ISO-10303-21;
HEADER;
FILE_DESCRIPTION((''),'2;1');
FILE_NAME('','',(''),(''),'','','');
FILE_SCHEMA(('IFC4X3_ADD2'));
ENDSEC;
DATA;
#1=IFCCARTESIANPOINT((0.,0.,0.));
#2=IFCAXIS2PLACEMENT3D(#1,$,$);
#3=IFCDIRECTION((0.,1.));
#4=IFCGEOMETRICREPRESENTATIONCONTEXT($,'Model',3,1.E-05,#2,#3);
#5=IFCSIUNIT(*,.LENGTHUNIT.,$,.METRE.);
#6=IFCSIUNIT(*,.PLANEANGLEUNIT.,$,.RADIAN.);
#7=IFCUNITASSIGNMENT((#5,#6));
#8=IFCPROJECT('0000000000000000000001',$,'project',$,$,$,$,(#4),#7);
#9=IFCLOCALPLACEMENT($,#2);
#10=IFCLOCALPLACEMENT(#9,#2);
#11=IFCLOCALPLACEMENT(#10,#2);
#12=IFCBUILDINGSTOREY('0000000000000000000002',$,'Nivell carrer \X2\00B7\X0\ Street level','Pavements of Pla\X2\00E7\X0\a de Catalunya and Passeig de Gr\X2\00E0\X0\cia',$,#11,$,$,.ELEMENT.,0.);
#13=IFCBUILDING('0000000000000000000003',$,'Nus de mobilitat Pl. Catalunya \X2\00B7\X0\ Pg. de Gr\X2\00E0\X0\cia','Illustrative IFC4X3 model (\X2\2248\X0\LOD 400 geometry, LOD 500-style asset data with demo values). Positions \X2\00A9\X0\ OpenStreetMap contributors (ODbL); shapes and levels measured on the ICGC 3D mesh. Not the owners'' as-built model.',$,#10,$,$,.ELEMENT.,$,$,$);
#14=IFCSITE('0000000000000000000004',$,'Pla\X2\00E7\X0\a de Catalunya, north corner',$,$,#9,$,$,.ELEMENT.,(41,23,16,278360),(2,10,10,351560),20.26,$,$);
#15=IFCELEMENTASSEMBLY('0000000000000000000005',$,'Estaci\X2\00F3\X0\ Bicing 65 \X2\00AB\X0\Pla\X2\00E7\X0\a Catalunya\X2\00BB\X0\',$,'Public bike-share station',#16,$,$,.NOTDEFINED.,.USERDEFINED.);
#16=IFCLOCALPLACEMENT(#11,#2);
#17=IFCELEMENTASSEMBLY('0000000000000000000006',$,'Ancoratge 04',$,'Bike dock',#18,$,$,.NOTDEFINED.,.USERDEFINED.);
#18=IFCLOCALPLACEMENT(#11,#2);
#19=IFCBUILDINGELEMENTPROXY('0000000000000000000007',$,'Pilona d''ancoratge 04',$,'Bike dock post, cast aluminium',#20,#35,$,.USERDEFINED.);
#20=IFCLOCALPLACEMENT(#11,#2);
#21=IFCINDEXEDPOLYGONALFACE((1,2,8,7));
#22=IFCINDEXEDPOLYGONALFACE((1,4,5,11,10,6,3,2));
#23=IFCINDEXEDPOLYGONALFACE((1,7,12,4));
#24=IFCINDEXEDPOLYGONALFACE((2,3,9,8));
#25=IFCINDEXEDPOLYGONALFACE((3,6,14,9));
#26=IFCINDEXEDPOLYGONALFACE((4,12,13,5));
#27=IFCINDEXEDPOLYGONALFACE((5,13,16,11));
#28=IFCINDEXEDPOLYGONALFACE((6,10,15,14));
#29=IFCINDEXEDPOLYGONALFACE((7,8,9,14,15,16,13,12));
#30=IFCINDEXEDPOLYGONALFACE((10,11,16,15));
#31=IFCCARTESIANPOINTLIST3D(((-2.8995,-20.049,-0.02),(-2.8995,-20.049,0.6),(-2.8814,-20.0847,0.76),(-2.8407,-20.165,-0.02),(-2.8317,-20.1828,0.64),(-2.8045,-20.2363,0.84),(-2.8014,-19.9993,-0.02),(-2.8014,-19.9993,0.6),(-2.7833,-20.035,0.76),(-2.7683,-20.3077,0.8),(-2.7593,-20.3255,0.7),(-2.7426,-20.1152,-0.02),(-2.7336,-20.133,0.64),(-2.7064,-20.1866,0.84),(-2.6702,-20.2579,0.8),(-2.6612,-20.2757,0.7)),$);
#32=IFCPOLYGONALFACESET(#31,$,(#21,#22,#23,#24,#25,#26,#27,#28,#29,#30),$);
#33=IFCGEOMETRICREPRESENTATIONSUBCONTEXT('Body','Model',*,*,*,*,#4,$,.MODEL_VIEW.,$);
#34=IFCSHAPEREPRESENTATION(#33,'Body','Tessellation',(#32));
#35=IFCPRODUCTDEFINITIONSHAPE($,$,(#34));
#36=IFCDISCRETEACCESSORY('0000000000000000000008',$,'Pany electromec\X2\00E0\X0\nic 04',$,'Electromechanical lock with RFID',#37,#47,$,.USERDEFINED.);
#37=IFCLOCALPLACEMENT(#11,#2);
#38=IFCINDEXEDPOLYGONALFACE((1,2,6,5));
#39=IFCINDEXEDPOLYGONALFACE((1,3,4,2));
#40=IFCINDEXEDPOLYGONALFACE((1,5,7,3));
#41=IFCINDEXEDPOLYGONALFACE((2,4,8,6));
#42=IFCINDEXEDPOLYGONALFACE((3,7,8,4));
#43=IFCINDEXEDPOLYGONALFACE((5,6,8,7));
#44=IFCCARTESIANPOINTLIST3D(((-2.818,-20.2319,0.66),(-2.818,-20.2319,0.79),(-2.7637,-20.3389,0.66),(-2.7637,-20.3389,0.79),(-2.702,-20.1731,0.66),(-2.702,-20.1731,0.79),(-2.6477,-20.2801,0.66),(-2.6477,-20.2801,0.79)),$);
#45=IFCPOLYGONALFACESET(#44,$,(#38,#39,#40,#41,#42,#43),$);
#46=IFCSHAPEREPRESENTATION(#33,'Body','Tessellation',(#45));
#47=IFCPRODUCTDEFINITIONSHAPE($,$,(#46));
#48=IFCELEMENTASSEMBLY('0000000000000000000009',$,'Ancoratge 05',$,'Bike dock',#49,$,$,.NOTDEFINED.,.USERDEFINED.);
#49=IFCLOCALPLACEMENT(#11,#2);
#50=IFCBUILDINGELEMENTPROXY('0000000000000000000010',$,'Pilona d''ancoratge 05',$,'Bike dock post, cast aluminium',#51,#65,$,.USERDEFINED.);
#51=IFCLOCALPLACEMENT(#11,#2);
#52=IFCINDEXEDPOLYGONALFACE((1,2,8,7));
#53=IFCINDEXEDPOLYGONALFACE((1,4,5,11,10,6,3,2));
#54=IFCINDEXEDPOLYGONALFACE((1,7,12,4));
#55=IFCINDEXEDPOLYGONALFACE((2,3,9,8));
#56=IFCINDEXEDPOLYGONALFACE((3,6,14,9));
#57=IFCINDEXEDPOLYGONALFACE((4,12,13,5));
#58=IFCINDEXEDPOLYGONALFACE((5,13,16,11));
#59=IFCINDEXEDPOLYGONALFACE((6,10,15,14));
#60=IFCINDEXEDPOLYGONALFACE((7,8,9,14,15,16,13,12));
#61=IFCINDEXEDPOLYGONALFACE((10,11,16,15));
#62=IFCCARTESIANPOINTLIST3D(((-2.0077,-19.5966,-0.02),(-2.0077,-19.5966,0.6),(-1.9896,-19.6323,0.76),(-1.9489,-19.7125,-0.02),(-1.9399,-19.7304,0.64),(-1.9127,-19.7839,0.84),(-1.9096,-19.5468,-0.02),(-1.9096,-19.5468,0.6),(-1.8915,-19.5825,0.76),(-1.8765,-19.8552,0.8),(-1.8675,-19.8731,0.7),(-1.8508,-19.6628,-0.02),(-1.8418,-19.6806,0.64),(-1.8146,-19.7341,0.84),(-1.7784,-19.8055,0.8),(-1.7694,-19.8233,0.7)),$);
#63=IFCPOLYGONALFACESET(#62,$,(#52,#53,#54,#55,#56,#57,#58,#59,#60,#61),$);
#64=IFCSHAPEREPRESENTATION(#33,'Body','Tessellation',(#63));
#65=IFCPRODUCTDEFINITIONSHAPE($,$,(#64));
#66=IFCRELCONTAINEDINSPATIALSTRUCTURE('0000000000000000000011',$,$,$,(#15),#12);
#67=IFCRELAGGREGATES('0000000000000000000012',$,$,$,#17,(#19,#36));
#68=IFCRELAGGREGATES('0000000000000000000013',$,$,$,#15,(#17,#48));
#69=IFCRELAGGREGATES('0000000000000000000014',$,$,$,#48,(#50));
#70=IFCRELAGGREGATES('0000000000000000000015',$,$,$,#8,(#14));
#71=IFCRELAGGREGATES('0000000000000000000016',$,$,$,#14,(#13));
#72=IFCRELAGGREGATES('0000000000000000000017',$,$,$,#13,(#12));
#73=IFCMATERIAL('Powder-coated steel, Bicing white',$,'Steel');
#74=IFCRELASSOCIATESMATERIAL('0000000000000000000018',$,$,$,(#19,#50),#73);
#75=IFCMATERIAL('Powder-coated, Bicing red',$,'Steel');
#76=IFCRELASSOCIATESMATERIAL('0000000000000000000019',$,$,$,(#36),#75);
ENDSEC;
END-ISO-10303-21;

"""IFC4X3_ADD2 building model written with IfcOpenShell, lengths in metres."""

from ifc_helpers import new_model, si_unit, direction, frame, frame_2d, origin, place, context, subcontext, project, spatial, polyline, rectangle, outline, extrude, material, element, aggregate, save


model = new_model("IFC4X3_ADD2")

# Units and contexts
model_context = context("Model", 3, precision=1e-05, world=origin(), true_north=direction((0.0, 1.0)))
body_context = subcontext(model_context, "Body", "Model", "MODEL_VIEW")
ifc_project = project(units=[si_unit("LENGTHUNIT", "METRE"), si_unit("PLANEANGLEUNIT", "RADIAN")], contexts=[model_context])

# Site, building, storey
site_placement = place(None, origin())
site = spatial("IfcSite", under=ifc_project, at=site_placement, Name="Plaça de Catalunya, north corner", CompositionType="ELEMENT", RefLatitude=(41, 23, 16, 278360), RefLongitude=(2, 10, 10, 351560), RefElevation=20.26)
building_placement = place(site_placement, origin())
building = spatial("IfcBuilding", under=site, at=building_placement, Name="Nus de mobilitat Pl. Catalunya · Pg. de Gràcia", Description="Illustrative IFC4X3 model (≈LOD 400 geometry, LOD 500-style asset data with demo values). Positions © OpenStreetMap contributors (ODbL); shapes and levels measured on the ICGC 3D mesh. Not the owners' as-built model.", CompositionType="ELEMENT")
storey_placement = place(building_placement, origin())
storey = spatial("IfcBuildingStorey", under=building, at=storey_placement, Name="Nivell carrer · Street level", Description="Pavements of Plaça de Catalunya and Passeig de Gràcia", CompositionType="ELEMENT", Elevation=0.0)

# Element assembly
assembly_1_placement = place(building_placement, origin())
assembly_1 = element("IfcElementAssembly", 1, at=assembly_1_placement, inside=storey, Name="Estació Bicing 65 «Plaça Catalunya»", ObjectType="Public bike-share station", AssemblyPlace="NOTDEFINED", PredefinedType="USERDEFINED")

# Element assembly
assembly_2_placement = place(building_placement, origin())
assembly_2 = element("IfcElementAssembly", 2, at=assembly_2_placement, Name="Ancoratge 04", ObjectType="Bike dock", AssemblyPlace="NOTDEFINED", PredefinedType="USERDEFINED")

# Shared definitions
ifc_material_1 = material(Name="Powder-coated steel, Bicing white", Category="Steel")

# Shared definitions
ifc_material_2 = material(Name="Powder-coated, Bicing red", Category="Steel")

# Building element proxy
proxy_1_placement = place(building_placement, origin())
proxy_1 = element("IfcBuildingElementProxy", 3, at=proxy_1_placement, material=ifc_material_1, Name="Pilona d'ancoratge 04", ObjectType="Bike dock post, cast aluminium", PredefinedType="USERDEFINED", context=body_context, shape_type="SweptSolid", body=[
    extrude(outline(polyline([(0.07, 0.06), (0.07, 0.68), (0.03, 0.84), (-0.14, 0.92), (-0.22, 0.88), (-0.24, 0.78), (-0.08, 0.72), (-0.06, 0.06), (0.07, 0.06)])), frame((-2.8679, -20.1115, -0.08), z_axis=(0.891798, 0.452435, 0.0), x_axis=(-0.452435, 0.891798, 0.0)), (0.0, 0.0, 1.0), 0.11),
])

# Discrete accessory
discrete_accessory_1_placement = place(building_placement, origin())
discrete_accessory_1 = element("IfcDiscreteAccessory", 4, at=discrete_accessory_1_placement, material=ifc_material_2, Name="Pany electromecànic 04", ObjectType="Electromechanical lock with RFID", PredefinedType="USERDEFINED", context=body_context, shape_type="SweptSolid", body=[
    extrude(rectangle(XDim=0.13, YDim=0.12, at=frame_2d((0.0, 0.0), x_axis=(0.891798, 0.452435))), frame((-2.7329, -20.256, 0.66)), (0.0, 0.0, 1.0), 0.13),
])
aggregate(assembly_2, [proxy_1, discrete_accessory_1])

# Element assembly
assembly_3_placement = place(building_placement, origin())
assembly_3 = element("IfcElementAssembly", 5, at=assembly_3_placement, Name="Ancoratge 05", ObjectType="Bike dock", AssemblyPlace="NOTDEFINED", PredefinedType="USERDEFINED")
aggregate(assembly_1, [assembly_2, assembly_3])

# Building element proxy
proxy_2_placement = place(building_placement, origin())
proxy_2 = element("IfcBuildingElementProxy", 6, at=proxy_2_placement, material=ifc_material_1, Name="Pilona d'ancoratge 05", ObjectType="Bike dock post, cast aluminium", PredefinedType="USERDEFINED", context=body_context, shape_type="SweptSolid", body=[
    extrude(outline(polyline([(0.07, 0.06), (0.07, 0.68), (0.03, 0.84), (-0.14, 0.92), (-0.22, 0.88), (-0.24, 0.78), (-0.08, 0.72), (-0.06, 0.06), (0.07, 0.06)])), frame((-1.9761, -19.659, -0.08), z_axis=(0.891798, 0.452435, 0.0), x_axis=(-0.452435, 0.891798, 0.0)), (0.0, 0.0, 1.0), 0.11),
])
aggregate(assembly_3, [proxy_2])

save(model, "model.ifc")
